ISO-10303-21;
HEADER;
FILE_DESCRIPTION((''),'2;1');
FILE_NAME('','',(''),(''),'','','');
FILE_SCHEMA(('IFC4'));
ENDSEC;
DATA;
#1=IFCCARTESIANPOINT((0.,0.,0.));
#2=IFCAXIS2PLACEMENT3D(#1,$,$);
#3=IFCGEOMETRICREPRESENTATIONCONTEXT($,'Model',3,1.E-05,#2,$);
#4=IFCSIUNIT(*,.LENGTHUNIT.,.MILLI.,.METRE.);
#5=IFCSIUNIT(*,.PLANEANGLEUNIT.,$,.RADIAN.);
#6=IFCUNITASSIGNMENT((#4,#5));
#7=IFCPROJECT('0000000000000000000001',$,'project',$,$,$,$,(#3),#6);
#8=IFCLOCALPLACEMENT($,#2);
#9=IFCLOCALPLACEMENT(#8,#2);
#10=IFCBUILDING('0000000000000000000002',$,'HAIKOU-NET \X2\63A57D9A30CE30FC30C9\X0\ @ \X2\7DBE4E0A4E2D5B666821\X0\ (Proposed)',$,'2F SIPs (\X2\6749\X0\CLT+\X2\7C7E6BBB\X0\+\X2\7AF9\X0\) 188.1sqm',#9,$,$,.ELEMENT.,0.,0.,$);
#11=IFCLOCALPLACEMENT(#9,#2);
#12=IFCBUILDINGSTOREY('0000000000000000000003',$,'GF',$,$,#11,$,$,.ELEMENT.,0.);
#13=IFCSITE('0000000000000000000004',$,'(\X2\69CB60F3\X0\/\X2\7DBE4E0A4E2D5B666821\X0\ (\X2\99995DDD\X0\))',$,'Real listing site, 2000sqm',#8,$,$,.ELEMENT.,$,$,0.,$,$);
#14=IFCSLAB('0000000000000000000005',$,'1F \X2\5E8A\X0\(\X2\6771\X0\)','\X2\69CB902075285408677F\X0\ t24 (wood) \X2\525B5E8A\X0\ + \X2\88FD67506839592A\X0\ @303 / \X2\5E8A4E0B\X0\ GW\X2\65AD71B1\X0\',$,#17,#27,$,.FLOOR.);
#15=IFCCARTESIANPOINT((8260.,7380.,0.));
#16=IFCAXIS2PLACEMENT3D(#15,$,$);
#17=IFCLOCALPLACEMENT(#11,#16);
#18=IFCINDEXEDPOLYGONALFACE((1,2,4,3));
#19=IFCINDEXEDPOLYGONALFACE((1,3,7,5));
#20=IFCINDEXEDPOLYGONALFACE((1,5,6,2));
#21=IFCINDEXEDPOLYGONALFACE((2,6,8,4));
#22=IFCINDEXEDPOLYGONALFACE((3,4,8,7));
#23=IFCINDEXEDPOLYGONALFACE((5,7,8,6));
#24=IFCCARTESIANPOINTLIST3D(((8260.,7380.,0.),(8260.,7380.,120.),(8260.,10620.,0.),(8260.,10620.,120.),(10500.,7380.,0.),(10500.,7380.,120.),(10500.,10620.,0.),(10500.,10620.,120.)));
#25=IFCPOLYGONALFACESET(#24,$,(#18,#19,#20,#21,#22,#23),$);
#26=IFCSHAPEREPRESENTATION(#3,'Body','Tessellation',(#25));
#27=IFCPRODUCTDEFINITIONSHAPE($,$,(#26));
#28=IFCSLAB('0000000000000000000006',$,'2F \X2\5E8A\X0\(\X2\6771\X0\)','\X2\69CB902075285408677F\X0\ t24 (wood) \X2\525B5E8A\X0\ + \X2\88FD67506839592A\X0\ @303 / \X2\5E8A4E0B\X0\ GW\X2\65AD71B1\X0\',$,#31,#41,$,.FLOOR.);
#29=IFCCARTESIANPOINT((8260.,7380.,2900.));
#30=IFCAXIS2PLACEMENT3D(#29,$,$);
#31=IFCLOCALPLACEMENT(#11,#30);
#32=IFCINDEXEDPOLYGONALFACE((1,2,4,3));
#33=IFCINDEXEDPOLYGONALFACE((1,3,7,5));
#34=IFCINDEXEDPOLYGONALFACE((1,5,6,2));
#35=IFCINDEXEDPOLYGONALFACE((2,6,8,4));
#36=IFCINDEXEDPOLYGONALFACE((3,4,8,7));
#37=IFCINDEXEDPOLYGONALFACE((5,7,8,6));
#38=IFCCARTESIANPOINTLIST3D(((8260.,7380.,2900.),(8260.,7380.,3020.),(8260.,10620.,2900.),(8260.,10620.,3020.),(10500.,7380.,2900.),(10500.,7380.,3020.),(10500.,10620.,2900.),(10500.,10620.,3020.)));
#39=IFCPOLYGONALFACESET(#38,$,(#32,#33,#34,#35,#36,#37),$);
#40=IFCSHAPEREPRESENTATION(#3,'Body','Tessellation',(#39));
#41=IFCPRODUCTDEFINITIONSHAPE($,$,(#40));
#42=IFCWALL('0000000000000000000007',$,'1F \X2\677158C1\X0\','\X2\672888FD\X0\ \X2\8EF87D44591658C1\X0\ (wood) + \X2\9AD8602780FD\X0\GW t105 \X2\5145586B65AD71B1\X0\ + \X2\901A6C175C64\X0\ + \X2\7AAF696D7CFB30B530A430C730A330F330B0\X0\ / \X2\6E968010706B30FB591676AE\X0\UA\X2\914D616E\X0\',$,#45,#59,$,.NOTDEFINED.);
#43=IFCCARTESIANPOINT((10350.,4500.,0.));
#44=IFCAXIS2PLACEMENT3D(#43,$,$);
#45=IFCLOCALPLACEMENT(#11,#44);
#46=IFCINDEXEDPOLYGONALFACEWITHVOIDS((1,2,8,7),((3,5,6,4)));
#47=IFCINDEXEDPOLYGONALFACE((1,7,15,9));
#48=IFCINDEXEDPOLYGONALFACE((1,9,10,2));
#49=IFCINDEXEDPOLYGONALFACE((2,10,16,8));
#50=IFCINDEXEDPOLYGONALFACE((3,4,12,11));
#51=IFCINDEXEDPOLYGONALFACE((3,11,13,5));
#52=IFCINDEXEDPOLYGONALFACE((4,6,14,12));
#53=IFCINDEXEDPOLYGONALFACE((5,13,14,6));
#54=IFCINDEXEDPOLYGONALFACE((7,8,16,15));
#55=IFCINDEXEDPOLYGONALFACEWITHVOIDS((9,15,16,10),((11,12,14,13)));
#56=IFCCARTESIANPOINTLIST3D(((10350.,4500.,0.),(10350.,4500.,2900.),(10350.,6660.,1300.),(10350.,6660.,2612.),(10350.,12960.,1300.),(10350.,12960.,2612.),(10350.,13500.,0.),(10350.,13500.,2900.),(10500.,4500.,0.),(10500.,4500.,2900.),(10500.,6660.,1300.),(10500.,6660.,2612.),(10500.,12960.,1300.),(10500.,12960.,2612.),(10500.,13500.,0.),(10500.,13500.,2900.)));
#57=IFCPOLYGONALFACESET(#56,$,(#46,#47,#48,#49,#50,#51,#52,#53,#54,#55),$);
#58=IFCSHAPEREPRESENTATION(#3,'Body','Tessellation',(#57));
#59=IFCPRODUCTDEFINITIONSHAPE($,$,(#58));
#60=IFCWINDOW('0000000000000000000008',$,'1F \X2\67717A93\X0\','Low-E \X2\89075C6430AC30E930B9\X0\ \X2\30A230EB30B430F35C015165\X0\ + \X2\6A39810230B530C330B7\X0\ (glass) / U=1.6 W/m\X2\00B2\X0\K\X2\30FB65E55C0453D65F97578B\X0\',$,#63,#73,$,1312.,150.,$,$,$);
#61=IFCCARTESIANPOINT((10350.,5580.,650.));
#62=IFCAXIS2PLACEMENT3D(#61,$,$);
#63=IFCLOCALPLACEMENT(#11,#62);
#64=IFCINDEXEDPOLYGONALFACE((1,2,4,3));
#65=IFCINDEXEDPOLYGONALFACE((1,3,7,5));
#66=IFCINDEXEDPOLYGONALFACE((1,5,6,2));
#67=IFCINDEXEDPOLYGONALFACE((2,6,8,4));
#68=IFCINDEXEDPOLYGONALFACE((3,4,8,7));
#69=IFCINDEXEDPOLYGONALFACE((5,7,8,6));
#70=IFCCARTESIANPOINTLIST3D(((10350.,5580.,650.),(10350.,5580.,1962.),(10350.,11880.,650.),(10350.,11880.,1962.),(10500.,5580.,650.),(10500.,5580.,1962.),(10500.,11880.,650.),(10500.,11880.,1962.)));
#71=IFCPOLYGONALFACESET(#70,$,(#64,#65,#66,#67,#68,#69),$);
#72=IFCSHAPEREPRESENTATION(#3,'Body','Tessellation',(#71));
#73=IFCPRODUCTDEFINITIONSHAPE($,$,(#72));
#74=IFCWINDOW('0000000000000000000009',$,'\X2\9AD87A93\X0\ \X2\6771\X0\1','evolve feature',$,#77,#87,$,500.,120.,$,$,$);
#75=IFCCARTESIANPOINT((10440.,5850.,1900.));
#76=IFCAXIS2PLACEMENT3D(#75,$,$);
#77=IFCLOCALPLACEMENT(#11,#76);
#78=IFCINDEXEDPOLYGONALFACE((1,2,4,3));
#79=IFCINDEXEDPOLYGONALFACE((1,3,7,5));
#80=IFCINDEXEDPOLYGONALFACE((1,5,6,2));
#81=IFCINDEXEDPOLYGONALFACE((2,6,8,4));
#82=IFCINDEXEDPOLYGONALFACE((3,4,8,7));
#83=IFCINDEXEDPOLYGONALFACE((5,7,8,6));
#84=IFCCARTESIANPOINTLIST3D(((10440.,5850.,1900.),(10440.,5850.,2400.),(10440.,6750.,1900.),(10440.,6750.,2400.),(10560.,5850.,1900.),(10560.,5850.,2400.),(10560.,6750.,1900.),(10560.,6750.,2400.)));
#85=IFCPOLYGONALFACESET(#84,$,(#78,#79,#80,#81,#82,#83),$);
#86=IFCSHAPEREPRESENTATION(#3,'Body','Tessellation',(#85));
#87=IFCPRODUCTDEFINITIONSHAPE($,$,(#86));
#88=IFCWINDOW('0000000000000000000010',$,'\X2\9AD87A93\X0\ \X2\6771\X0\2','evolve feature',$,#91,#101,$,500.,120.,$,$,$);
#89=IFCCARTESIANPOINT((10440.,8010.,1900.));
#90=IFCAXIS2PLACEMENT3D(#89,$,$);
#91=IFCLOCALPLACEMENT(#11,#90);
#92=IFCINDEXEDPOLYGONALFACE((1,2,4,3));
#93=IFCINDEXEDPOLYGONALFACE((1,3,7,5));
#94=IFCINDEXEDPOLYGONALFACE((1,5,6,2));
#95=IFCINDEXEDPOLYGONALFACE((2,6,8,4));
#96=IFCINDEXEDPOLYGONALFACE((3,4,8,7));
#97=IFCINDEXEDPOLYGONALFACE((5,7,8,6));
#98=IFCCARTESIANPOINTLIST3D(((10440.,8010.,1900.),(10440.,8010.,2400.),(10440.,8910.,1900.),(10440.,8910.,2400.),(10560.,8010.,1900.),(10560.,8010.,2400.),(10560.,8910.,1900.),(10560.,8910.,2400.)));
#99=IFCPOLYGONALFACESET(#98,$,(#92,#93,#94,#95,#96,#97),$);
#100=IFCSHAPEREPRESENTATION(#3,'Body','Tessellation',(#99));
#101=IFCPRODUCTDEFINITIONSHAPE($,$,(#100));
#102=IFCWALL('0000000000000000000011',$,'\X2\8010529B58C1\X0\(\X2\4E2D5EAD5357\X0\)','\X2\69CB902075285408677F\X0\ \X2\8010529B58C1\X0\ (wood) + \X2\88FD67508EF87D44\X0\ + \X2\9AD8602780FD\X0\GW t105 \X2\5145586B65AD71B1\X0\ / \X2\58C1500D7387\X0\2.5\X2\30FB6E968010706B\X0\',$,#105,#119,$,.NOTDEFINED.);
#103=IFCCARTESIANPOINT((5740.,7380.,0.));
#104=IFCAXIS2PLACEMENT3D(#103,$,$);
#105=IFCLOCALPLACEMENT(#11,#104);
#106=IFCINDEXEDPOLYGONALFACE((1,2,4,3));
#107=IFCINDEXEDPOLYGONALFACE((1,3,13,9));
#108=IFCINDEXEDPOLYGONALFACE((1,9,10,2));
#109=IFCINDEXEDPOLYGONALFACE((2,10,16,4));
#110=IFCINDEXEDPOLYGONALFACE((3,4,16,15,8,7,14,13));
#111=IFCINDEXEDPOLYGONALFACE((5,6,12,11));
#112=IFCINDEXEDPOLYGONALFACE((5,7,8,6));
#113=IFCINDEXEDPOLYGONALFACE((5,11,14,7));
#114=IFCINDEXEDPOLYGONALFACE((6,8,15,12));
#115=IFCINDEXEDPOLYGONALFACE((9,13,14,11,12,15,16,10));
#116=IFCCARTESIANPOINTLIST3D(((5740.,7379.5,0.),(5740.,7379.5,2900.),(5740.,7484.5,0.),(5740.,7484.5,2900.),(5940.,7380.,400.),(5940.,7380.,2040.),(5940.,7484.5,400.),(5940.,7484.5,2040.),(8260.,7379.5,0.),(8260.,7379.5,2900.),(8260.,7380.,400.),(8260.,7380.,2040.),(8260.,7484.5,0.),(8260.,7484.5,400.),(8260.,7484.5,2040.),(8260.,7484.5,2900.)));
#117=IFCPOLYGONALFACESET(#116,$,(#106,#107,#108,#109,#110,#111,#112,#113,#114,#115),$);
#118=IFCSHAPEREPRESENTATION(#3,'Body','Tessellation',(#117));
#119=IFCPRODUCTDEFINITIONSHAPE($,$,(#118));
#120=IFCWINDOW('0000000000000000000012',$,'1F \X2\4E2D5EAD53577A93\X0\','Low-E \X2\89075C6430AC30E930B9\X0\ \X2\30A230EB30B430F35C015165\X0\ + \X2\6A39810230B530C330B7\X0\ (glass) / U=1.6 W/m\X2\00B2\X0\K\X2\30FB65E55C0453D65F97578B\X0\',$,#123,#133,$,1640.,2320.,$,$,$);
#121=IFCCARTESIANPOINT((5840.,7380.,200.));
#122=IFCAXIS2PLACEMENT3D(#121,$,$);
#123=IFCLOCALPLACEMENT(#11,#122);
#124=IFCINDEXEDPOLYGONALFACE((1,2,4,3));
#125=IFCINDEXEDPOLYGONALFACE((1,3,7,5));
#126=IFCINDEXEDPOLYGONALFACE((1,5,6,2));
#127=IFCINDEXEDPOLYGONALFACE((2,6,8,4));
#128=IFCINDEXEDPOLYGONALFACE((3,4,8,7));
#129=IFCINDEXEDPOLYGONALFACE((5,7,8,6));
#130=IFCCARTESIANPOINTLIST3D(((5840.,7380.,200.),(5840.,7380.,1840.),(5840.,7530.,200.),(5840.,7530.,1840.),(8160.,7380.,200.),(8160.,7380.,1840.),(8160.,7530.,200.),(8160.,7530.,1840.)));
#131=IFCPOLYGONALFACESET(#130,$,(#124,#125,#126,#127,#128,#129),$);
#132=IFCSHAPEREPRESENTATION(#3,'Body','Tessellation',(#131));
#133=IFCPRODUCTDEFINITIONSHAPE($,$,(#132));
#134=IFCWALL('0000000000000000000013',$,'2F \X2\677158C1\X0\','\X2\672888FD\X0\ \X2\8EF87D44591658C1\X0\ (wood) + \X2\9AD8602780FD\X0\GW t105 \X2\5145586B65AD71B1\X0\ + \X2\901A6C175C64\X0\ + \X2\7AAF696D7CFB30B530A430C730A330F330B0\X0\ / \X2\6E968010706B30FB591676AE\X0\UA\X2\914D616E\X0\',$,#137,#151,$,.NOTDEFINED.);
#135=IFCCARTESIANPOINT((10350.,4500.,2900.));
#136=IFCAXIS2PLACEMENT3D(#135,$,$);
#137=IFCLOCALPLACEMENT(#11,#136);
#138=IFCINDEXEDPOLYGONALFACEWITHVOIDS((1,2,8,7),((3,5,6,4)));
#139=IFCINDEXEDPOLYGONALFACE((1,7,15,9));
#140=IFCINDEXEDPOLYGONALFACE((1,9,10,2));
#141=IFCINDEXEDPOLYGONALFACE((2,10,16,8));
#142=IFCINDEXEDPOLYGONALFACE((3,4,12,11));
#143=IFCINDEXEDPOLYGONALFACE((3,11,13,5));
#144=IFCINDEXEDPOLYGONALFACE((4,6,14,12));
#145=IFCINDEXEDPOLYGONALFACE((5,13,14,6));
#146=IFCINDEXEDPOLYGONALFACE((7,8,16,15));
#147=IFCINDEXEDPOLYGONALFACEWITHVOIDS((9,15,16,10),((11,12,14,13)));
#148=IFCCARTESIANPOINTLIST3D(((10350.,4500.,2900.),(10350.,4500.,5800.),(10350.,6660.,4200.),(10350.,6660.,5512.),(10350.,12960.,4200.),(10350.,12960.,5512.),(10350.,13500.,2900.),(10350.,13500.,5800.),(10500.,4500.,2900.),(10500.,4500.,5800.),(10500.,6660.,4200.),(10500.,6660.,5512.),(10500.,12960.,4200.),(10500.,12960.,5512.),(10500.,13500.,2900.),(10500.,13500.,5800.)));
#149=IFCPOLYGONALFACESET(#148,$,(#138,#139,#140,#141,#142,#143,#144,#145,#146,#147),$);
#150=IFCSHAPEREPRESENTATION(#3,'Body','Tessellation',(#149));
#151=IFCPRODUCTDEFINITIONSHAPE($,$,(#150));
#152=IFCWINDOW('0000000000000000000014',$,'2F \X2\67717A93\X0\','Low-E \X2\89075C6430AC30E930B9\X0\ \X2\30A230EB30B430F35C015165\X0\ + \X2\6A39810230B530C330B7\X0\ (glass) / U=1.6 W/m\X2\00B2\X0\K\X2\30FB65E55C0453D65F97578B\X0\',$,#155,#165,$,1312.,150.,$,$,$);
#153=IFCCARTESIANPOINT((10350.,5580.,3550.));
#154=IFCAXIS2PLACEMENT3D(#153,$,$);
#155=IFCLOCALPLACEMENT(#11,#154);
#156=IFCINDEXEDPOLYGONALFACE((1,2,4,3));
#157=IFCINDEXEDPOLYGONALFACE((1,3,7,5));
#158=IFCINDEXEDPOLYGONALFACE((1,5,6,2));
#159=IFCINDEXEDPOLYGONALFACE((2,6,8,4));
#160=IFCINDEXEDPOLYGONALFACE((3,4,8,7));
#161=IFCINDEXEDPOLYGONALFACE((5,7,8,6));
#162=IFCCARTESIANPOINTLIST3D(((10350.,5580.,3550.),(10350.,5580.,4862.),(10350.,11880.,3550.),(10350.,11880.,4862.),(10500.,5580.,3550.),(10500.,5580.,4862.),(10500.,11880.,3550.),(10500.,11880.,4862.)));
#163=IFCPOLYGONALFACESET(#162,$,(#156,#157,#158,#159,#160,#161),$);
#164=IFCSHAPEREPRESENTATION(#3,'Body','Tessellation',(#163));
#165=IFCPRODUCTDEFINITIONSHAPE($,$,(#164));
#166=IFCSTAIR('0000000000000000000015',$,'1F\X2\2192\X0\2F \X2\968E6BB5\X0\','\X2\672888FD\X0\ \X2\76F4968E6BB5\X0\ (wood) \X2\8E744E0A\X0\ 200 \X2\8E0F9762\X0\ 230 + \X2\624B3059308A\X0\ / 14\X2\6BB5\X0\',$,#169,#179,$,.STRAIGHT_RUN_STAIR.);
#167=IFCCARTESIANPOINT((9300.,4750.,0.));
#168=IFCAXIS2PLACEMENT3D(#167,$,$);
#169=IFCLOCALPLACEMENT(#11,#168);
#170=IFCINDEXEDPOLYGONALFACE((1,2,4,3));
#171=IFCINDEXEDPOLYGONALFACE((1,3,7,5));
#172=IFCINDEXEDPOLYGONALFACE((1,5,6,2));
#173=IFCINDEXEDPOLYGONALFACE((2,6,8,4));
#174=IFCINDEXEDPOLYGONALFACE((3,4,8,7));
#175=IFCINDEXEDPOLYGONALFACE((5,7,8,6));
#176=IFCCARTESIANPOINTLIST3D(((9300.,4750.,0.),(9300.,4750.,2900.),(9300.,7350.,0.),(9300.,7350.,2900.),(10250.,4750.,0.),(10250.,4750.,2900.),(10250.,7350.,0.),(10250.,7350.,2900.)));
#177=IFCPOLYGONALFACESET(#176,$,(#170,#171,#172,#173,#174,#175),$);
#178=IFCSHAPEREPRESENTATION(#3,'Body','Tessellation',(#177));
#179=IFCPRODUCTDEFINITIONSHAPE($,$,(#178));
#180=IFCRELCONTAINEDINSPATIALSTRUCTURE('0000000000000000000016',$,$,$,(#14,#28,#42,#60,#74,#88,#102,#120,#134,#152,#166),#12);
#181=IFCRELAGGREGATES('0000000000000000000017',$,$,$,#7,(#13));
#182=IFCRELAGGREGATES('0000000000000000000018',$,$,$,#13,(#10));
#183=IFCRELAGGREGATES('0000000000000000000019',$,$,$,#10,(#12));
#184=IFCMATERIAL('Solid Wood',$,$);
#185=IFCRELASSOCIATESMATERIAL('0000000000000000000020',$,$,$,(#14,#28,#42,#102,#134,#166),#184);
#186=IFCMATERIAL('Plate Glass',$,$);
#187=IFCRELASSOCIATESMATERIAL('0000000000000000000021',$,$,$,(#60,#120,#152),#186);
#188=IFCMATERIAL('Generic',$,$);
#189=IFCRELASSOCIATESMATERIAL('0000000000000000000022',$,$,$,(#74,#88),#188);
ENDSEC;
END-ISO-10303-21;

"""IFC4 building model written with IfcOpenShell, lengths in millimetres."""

from ifc_helpers import new_model, si_unit, frame, frame_2d, origin, place, context, project, spatial, rectangle, extrude, material, element, fill, save


model = new_model("IFC4")

# Units and contexts
model_context = context("Model", 3, precision=1e-05, world=origin())
ifc_project = project(units=[si_unit("LENGTHUNIT", "METRE", prefix="MILLI"), si_unit("PLANEANGLEUNIT", "RADIAN")], contexts=[model_context])

# Site, building, storey
site_placement = place(None, origin())
site = spatial("IfcSite", under=ifc_project, at=site_placement, Name="(構想/綾上中学校 (香川))", ObjectType="Real listing site, 2000sqm", CompositionType="ELEMENT", RefElevation=0.0)
building_placement = place(site_placement, origin())
building = spatial("IfcBuilding", under=site, at=building_placement, Name="HAIKOU-NET 接続ノード @ 綾上中学校 (Proposed)", ObjectType="2F SIPs (杉CLT+籾殻+竹) 188.1sqm", CompositionType="ELEMENT", ElevationOfRefHeight=0.0, ElevationOfTerrain=0.0)
storey_placement = place(building_placement, origin())
storey = spatial("IfcBuildingStorey", under=building, at=storey_placement, Name="GF", CompositionType="ELEMENT", Elevation=0.0)

# Slabs
ifc_material_1 = material(Name="Solid Wood")
slab_1_placement = place(storey_placement, frame((8260.0, 7380.0, 0.0)))
element("IfcSlab", 1, at=slab_1_placement, inside=storey, material=ifc_material_1, Name="1F 床(東)", Description="構造用合板 t24 (wood) 剛床 + 製材根太 @303 / 床下 GW断熱", PredefinedType="FLOOR", context=model_context, shape_type="SweptSolid", body=[
    extrude(rectangle(XDim=2240.0, YDim=3240.0, at=frame_2d((1120.0, 1620.0))), frame((8260.0, 7380.0, 0.0)), (0.0, 0.0, 1.0), 120.0),
])
slab_2_placement = place(storey_placement, frame((8260.0, 7380.0, 2900.0)))
element("IfcSlab", 2, at=slab_2_placement, inside=storey, material=ifc_material_1, Name="2F 床(東)", Description="構造用合板 t24 (wood) 剛床 + 製材根太 @303 / 床下 GW断熱", PredefinedType="FLOOR", context=model_context, shape_type="SweptSolid", body=[
    extrude(rectangle(XDim=2240.0, YDim=3240.0, at=frame_2d((1120.0, 1620.0))), frame((8260.0, 7380.0, 2900.0)), (0.0, 0.0, 1.0), 120.0),
])

# Wall, openings, windows
wall_1_placement = place(storey_placement, frame((10350.0, 4500.0, 0.0)))
wall_1 = element("IfcWall", 3, at=wall_1_placement, inside=storey, material=ifc_material_1, Name="1F 東壁", Description="木製 軸組外壁 (wood) + 高性能GW t105 充填断熱 + 通気層 + 窯業系サイディング / 準耐火・外皮UA配慮", PredefinedType="NOTDEFINED", context=model_context, shape_type="SweptSolid", body=[
    extrude(rectangle(XDim=150.0, YDim=9000.0, at=frame_2d((75.0, 4500.0))), frame((10350.0, 4500.0, 0.0)), (0.0, 0.0, 1.0), 2900.0),
])
opening_1_placement = place(storey_placement, frame((10350.0, 5580.0, 650.0)))
opening_1 = element("IfcOpeningElement", 4, at=opening_1_placement, cuts=wall_1, PredefinedType="NOTDEFINED", context=model_context, shape_type="SweptSolid", body=[
    extrude(rectangle(XDim=150.0, YDim=6300.0, at=frame_2d((75.0, 3150.0))), frame((10350.0, 5580.0, 650.0)), (0.0, 0.0, 1.0), 1312.0),
])
opening_2_placement = place(storey_placement, frame((10440.0, 5850.0, 1900.0)))
opening_2 = element("IfcOpeningElement", 5, at=opening_2_placement, cuts=wall_1, PredefinedType="NOTDEFINED", context=model_context, shape_type="SweptSolid", body=[
    extrude(rectangle(XDim=120.0, YDim=900.0, at=frame_2d((60.0, 450.0))), frame((10440.0, 5850.0, 1900.0)), (0.0, 0.0, 1.0), 500.0),
])
opening_3_placement = place(storey_placement, frame((10440.0, 8010.0, 1900.0)))
opening_3 = element("IfcOpeningElement", 6, at=opening_3_placement, cuts=wall_1, PredefinedType="NOTDEFINED", context=model_context, shape_type="SweptSolid", body=[
    extrude(rectangle(XDim=120.0, YDim=900.0, at=frame_2d((60.0, 450.0))), frame((10440.0, 8010.0, 1900.0)), (0.0, 0.0, 1.0), 500.0),
])
ifc_material_2 = material(Name="Plate Glass")
window_1_placement = place(storey_placement, frame((10350.0, 5580.0, 650.0)))
window_1 = element("IfcWindow", 7, at=window_1_placement, inside=storey, material=ifc_material_2, Name="1F 東窓", Description="Low-E 複層ガラス アルゴン封入 + 樹脂サッシ (glass) / U=1.6 W/m²K・日射取得型", OverallHeight=1312.0, OverallWidth=150.0, context=model_context, shape_type="SweptSolid", body=[
    extrude(rectangle(XDim=150.0, YDim=6300.0, at=frame_2d((75.0, 3150.0))), frame((10350.0, 5580.0, 650.0)), (0.0, 0.0, 1.0), 1312.0),
])
fill(opening_1, window_1)
ifc_material_3 = material(Name="Generic")
window_2_placement = place(storey_placement, frame((10440.0, 5850.0, 1900.0)))
window_2 = element("IfcWindow", 8, at=window_2_placement, inside=storey, material=ifc_material_3, Name="高窓 東1", Description="evolve feature", OverallHeight=500.0, OverallWidth=120.0, context=model_context, shape_type="SweptSolid", body=[
    extrude(rectangle(XDim=120.0, YDim=900.0, at=frame_2d((60.0, 450.0))), frame((10440.0, 5850.0, 1900.0)), (0.0, 0.0, 1.0), 500.0),
])
fill(opening_2, window_2)
window_3_placement = place(storey_placement, frame((10440.0, 8010.0, 1900.0)))
window_3 = element("IfcWindow", 9, at=window_3_placement, inside=storey, material=ifc_material_3, Name="高窓 東2", Description="evolve feature", OverallHeight=500.0, OverallWidth=120.0, context=model_context, shape_type="SweptSolid", body=[
    extrude(rectangle(XDim=120.0, YDim=900.0, at=frame_2d((60.0, 450.0))), frame((10440.0, 8010.0, 1900.0)), (0.0, 0.0, 1.0), 500.0),
])
fill(opening_3, window_3)

# Wall, opening, window
wall_2_placement = place(storey_placement, frame((5740.0, 7380.0, 0.0)))
wall_2 = element("IfcWall", 10, at=wall_2_placement, inside=storey, material=ifc_material_1, Name="耐力壁(中庭南)", Description="構造用合板 耐力壁 (wood) + 製材軸組 + 高性能GW t105 充填断熱 / 壁倍率2.5・準耐火", PredefinedType="NOTDEFINED", context=model_context, shape_type="SweptSolid", body=[
    extrude(rectangle(XDim=2520.0, YDim=105.0, at=frame_2d((1260.0, 52.0))), frame((5740.0, 7380.0, 0.0)), (0.0, 0.0, 1.0), 2900.0),
])
opening_4_placement = place(storey_placement, frame((5840.0, 7380.0, 200.0)))
opening_4 = element("IfcOpeningElement", 11, at=opening_4_placement, cuts=wall_2, PredefinedType="NOTDEFINED", context=model_context, shape_type="SweptSolid", body=[
    extrude(rectangle(XDim=2320.0, YDim=150.0, at=frame_2d((1160.0, 75.0))), frame((5840.0, 7380.0, 200.0)), (0.0, 0.0, 1.0), 1640.0),
])
window_4_placement = place(storey_placement, frame((5840.0, 7380.0, 200.0)))
window_4 = element("IfcWindow", 12, at=window_4_placement, inside=storey, material=ifc_material_2, Name="1F 中庭南窓", Description="Low-E 複層ガラス アルゴン封入 + 樹脂サッシ (glass) / U=1.6 W/m²K・日射取得型", OverallHeight=1640.0, OverallWidth=2320.0, context=model_context, shape_type="SweptSolid", body=[
    extrude(rectangle(XDim=2320.0, YDim=150.0, at=frame_2d((1160.0, 75.0))), frame((5840.0, 7380.0, 200.0)), (0.0, 0.0, 1.0), 1640.0),
])
fill(opening_4, window_4)

# Wall, opening, window
wall_3_placement = place(storey_placement, frame((10350.0, 4500.0, 2900.0)))
wall_3 = element("IfcWall", 13, at=wall_3_placement, inside=storey, material=ifc_material_1, Name="2F 東壁", Description="木製 軸組外壁 (wood) + 高性能GW t105 充填断熱 + 通気層 + 窯業系サイディング / 準耐火・外皮UA配慮", PredefinedType="NOTDEFINED", context=model_context, shape_type="SweptSolid", body=[
    extrude(rectangle(XDim=150.0, YDim=9000.0, at=frame_2d((75.0, 4500.0))), frame((10350.0, 4500.0, 2900.0)), (0.0, 0.0, 1.0), 2900.0),
])
opening_5_placement = place(storey_placement, frame((10350.0, 5580.0, 3550.0)))
opening_5 = element("IfcOpeningElement", 14, at=opening_5_placement, cuts=wall_3, PredefinedType="NOTDEFINED", context=model_context, shape_type="SweptSolid", body=[
    extrude(rectangle(XDim=150.0, YDim=6300.0, at=frame_2d((75.0, 3150.0))), frame((10350.0, 5580.0, 3550.0)), (0.0, 0.0, 1.0), 1312.0),
])
window_5_placement = place(storey_placement, frame((10350.0, 5580.0, 3550.0)))
window_5 = element("IfcWindow", 15, at=window_5_placement, inside=storey, material=ifc_material_2, Name="2F 東窓", Description="Low-E 複層ガラス アルゴン封入 + 樹脂サッシ (glass) / U=1.6 W/m²K・日射取得型", OverallHeight=1312.0, OverallWidth=150.0, context=model_context, shape_type="SweptSolid", body=[
    extrude(rectangle(XDim=150.0, YDim=6300.0, at=frame_2d((75.0, 3150.0))), frame((10350.0, 5580.0, 3550.0)), (0.0, 0.0, 1.0), 1312.0),
])
fill(opening_5, window_5)

# Stair
stair_placement = place(storey_placement, frame((9300.0, 4750.0, 0.0)))
element("IfcStair", 16, at=stair_placement, inside=storey, material=ifc_material_1, Name="1F→2F 階段", Description="木製 直階段 (wood) 蹴上 200 踏面 230 + 手すり / 14段", PredefinedType="STRAIGHT_RUN_STAIR", context=model_context, shape_type="SweptSolid", body=[
    extrude(rectangle(XDim=950.0, YDim=2600.0, at=frame_2d((475.0, 1300.0))), frame((9300.0, 4750.0, 0.0)), (0.0, 0.0, 1.0), 2900.0),
])

save(model, "model.ifc")
